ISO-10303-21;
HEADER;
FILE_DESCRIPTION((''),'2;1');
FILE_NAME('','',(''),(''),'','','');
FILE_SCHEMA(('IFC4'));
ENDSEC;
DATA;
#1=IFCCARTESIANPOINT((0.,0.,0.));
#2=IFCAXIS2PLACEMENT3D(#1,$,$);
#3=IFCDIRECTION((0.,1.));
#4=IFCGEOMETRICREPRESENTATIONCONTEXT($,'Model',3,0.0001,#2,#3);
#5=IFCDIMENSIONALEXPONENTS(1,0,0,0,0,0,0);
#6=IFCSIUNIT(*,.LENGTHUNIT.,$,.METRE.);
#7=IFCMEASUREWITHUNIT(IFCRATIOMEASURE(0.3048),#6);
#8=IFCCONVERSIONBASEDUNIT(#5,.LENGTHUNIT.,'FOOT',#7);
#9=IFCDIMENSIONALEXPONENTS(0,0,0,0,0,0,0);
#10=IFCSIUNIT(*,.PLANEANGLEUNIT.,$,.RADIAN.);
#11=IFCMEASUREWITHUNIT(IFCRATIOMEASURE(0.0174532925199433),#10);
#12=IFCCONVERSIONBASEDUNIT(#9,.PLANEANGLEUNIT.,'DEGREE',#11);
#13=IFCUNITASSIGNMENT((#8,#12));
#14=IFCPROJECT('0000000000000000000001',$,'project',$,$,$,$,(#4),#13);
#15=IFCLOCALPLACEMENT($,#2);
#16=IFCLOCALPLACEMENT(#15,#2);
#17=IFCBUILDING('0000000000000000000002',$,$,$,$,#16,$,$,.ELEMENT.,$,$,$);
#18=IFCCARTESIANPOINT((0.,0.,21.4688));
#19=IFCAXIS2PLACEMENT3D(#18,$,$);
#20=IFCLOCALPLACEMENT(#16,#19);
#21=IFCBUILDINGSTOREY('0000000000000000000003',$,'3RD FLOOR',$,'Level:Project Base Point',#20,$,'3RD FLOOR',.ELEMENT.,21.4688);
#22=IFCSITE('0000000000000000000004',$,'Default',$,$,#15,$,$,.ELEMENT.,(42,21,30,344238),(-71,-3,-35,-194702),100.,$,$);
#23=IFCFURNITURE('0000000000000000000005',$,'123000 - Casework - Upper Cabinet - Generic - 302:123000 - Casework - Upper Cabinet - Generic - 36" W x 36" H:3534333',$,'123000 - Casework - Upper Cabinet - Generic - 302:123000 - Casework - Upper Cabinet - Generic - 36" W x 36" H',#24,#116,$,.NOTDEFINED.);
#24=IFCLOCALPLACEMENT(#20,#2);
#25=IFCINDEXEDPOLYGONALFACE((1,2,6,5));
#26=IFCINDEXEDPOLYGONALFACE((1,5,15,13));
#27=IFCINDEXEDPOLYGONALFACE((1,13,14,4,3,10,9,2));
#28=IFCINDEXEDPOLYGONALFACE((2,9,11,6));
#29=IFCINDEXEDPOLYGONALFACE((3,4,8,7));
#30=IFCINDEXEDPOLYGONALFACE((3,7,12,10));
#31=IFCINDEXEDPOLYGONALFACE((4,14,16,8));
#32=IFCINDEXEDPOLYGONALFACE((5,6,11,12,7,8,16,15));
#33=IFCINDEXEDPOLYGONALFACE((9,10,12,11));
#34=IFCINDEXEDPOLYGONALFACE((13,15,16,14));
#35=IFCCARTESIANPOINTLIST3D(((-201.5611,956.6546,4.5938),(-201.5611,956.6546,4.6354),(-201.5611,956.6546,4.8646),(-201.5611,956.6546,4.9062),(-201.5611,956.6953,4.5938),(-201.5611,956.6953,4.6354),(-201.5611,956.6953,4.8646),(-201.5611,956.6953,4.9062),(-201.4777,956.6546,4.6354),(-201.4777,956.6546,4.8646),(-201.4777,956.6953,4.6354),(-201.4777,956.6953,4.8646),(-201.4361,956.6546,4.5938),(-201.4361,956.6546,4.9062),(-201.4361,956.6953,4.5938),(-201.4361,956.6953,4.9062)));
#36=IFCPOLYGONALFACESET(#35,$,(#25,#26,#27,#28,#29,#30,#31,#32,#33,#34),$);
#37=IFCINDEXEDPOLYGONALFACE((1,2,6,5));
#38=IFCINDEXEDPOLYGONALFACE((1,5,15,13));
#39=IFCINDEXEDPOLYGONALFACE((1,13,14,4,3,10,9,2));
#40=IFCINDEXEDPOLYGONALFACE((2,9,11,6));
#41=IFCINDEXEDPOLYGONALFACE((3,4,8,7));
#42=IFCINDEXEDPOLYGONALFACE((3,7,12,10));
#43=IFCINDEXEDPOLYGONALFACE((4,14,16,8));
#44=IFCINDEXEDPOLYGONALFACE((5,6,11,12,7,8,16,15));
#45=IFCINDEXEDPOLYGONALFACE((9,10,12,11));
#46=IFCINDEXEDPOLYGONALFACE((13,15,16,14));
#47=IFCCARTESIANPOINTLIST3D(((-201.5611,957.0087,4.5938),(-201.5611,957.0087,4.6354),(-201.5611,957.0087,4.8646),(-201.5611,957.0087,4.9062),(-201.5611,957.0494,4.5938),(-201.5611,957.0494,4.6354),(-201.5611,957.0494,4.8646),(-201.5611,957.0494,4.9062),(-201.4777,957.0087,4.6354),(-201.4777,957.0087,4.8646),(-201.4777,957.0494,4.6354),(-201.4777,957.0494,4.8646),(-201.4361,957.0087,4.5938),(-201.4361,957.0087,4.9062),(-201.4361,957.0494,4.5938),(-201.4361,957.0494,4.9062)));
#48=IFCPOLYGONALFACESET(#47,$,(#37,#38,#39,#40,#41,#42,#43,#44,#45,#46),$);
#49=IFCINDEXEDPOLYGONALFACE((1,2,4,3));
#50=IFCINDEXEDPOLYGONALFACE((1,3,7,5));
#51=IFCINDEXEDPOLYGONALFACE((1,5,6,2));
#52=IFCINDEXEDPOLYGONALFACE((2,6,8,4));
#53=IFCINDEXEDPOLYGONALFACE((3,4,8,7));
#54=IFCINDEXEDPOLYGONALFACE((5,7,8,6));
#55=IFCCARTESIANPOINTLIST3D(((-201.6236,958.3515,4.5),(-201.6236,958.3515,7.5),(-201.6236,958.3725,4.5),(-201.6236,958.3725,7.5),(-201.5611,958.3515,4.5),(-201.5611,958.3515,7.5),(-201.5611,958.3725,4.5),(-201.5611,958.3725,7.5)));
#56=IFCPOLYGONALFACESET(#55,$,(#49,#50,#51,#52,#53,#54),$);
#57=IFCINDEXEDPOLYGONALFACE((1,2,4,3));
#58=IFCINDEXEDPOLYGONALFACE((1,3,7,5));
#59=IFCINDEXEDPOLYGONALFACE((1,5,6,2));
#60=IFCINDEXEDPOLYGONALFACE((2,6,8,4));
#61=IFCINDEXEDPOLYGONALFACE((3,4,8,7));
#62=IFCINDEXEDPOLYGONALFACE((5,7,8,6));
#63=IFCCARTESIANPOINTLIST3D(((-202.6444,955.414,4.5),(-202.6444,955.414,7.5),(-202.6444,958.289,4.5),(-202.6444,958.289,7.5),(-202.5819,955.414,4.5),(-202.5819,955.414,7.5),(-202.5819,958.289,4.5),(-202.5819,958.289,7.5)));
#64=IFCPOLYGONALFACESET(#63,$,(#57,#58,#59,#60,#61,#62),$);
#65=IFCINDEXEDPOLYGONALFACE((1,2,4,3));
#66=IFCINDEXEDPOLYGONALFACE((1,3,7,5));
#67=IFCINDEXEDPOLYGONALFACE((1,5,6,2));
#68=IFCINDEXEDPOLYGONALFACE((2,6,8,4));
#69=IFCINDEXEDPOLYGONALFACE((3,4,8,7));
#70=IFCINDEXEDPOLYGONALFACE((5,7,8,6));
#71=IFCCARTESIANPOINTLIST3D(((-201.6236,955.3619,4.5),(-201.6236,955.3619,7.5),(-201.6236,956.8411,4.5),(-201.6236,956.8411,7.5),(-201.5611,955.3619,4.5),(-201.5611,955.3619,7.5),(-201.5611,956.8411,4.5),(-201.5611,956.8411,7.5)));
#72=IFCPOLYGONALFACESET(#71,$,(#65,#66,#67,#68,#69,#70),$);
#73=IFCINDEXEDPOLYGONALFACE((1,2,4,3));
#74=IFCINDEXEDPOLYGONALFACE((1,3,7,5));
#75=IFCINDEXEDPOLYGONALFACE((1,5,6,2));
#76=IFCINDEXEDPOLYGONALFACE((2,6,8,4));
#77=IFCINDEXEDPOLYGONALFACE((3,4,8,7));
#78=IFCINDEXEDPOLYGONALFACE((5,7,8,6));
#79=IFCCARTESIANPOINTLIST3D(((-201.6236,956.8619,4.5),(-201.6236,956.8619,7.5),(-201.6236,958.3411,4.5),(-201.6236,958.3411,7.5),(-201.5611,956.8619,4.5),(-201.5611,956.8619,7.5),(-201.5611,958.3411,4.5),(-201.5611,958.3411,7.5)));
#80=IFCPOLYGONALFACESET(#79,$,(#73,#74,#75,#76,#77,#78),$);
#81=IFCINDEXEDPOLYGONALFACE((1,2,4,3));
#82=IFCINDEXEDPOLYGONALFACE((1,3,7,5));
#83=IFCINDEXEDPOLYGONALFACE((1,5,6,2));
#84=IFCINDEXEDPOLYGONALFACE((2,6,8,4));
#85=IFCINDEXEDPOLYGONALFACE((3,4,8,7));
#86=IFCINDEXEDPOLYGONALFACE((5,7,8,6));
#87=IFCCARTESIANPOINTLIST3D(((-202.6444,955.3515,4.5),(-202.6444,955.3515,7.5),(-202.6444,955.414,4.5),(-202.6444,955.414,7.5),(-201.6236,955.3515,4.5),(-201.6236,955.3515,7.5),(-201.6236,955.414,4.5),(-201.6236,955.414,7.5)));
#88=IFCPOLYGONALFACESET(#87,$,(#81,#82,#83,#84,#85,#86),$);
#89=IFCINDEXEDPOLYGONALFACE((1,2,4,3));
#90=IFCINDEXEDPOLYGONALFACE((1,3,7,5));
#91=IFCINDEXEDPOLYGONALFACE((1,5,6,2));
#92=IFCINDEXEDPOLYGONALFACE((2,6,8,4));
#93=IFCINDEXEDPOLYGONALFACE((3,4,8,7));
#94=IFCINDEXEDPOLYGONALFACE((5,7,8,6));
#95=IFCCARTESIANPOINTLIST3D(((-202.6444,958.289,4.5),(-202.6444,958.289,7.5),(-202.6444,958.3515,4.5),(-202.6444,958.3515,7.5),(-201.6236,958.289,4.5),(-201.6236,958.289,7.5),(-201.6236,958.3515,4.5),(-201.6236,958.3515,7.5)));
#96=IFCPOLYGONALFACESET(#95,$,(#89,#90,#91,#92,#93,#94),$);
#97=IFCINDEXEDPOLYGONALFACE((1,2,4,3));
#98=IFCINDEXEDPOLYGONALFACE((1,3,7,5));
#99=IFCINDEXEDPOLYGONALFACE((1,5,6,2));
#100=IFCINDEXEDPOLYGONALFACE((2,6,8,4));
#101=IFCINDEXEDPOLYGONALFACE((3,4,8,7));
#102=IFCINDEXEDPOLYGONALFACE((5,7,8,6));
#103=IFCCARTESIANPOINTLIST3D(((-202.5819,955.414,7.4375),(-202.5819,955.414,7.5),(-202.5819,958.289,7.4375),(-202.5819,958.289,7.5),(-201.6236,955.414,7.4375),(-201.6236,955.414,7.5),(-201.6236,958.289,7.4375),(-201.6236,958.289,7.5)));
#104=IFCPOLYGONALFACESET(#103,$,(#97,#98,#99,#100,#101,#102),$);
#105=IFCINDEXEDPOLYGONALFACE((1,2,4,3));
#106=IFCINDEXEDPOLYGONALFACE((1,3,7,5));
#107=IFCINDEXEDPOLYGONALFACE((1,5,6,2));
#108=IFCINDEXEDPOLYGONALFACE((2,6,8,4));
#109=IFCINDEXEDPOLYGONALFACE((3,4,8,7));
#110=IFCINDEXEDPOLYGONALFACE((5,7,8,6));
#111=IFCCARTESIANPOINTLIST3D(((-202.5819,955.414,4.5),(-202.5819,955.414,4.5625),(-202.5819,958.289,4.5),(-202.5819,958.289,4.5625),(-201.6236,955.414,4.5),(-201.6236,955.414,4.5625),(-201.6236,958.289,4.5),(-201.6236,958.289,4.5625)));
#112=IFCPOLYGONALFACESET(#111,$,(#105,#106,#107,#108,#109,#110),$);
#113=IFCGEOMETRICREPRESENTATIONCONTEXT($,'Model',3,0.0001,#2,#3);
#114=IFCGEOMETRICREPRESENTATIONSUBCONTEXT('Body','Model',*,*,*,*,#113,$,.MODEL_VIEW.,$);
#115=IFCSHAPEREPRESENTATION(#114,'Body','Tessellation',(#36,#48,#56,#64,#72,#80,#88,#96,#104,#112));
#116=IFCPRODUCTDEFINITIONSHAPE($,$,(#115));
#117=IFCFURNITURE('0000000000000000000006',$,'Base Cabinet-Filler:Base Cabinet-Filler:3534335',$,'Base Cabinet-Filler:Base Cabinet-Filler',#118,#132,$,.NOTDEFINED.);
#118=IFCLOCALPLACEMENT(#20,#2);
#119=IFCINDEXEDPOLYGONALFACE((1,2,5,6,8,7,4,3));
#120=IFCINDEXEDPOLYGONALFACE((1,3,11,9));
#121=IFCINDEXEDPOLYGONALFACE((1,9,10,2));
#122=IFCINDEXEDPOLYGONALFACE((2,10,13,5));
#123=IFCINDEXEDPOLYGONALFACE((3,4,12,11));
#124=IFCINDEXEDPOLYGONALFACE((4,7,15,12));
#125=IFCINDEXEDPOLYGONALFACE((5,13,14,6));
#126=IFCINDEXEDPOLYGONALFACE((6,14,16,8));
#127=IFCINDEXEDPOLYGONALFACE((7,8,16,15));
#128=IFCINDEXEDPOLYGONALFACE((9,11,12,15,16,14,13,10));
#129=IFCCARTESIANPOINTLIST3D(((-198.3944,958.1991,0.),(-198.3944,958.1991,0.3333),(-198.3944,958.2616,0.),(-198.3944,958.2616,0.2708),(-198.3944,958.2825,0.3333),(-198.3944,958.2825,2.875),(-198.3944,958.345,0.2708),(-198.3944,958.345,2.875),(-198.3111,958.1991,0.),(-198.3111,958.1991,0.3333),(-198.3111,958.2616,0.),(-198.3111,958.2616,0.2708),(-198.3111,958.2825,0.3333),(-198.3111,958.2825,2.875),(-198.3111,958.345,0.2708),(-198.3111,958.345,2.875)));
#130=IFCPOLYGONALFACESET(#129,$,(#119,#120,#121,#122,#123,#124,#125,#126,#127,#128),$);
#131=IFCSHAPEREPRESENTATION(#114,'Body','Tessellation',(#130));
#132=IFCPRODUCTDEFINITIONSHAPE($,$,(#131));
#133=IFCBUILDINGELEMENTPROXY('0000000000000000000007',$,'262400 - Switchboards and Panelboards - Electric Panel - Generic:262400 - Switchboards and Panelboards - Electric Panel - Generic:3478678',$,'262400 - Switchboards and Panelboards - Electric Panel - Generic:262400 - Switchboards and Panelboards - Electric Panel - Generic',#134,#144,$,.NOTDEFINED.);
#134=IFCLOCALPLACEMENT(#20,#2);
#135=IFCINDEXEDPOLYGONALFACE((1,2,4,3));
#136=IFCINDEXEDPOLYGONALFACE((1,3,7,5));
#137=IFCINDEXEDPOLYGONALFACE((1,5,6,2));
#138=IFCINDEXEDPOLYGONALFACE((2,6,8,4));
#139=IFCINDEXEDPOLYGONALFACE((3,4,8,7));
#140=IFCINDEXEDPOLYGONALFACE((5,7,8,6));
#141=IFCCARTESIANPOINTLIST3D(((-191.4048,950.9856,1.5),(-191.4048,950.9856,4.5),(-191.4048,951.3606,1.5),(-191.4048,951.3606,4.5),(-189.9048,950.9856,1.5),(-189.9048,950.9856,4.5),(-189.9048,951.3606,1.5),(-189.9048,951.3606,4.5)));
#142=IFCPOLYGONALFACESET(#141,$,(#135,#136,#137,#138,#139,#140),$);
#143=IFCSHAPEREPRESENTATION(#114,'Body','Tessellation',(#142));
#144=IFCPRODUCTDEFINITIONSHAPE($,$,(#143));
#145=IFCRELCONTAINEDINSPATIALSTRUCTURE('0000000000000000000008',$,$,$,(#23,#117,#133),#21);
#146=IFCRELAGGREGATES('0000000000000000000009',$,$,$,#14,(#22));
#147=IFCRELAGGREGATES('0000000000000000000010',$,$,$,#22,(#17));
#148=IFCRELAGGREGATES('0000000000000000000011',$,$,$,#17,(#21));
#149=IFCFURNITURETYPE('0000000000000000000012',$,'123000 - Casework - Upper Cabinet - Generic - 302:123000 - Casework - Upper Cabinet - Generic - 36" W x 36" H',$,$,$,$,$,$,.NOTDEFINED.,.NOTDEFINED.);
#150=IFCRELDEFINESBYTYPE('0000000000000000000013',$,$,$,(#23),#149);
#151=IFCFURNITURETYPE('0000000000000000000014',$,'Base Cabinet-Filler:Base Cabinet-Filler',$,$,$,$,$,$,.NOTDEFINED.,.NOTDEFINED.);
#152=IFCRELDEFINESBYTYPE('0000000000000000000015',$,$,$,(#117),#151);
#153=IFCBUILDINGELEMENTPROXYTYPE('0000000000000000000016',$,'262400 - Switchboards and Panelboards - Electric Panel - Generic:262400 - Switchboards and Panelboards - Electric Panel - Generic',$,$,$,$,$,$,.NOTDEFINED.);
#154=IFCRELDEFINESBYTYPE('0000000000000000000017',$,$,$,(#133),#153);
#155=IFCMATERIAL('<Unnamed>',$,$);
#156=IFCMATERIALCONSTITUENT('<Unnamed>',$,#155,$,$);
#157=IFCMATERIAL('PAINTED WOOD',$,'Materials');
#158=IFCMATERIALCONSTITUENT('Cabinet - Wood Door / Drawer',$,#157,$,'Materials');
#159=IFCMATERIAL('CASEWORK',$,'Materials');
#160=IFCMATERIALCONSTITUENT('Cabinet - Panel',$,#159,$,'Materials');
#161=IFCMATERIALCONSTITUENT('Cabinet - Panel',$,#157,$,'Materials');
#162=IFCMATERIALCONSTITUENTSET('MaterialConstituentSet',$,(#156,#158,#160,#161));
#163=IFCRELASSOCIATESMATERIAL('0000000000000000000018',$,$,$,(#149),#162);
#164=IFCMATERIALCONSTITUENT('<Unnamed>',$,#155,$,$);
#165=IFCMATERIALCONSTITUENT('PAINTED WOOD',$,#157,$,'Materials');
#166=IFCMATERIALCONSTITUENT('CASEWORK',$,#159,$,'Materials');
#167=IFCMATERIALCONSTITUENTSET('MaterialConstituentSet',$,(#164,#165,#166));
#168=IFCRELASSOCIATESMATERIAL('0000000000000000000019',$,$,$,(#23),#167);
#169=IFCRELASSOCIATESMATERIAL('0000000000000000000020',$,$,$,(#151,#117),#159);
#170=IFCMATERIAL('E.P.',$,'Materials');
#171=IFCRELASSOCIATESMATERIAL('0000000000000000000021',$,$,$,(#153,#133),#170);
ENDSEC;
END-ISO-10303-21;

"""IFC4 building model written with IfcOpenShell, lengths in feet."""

from ifc_helpers import new_model, entity, si_unit, converted_unit, direction, frame, frame_2d, origin, origin_2d_with_axis, place, context, subcontext, project, spatial, polyline, rectangle, outline, extrude, source, transform, mapped, material, constituent, constituent_set, type_object, type_shapes, element, save


model = new_model("IFC4")

# Units and contexts
model_context_1 = context("Model", 3, precision=0.0001, world=origin(), true_north=direction((0.0, 1.0)))
model_context_2 = context("Model", 3, precision=0.0001, world=origin(), true_north=direction((0.0, 1.0)))
body_context = subcontext(model_context_2, "Body", "Model", "MODEL_VIEW")
ifc_project = project(units=[converted_unit("LENGTHUNIT", "FOOT", entity("IfcRatioMeasure", 0.3048), si_unit("LENGTHUNIT", "METRE"), dimensions=[1, 0, 0, 0, 0, 0, 0]), converted_unit("PLANEANGLEUNIT", "DEGREE", entity("IfcRatioMeasure", 0.0174532925199433), si_unit("PLANEANGLEUNIT", "RADIAN"), dimensions=[0, 0, 0, 0, 0, 0, 0])], contexts=[model_context_1])

# Site, building, storey
site_placement = place(None, origin())
site = spatial("IfcSite", under=ifc_project, at=site_placement, Name="Default", CompositionType="ELEMENT", RefLatitude=(42, 21, 30, 344238), RefLongitude=(-71, -3, -35, -194702), RefElevation=100.0)
building_placement = place(site_placement, origin())
building = spatial("IfcBuilding", under=site, at=building_placement, CompositionType="ELEMENT")
storey_placement = place(building_placement, frame((0.0, 0.0, 21.4688)))
storey = spatial("IfcBuildingStorey", under=building, at=storey_placement, Name="3RD FLOOR", ObjectType="Level:Project Base Point", LongName="3RD FLOOR", CompositionType="ELEMENT", Elevation=21.4688)

# Furniture
ifc_material_1 = material(Name="CASEWORK", Category="Materials")
ifc_material_2 = material(Name="PAINTED WOOD", Category="Materials")
ifc_material_3 = material(Name="<Unnamed>")
ifc_constituent_1 = constituent(ifc_material_3, Name="<Unnamed>")
ifc_constituent_2 = constituent(ifc_material_2, Name="PAINTED WOOD", Category="Materials")
ifc_constituent_3 = constituent(ifc_material_1, Name="CASEWORK", Category="Materials")
ifc_constituent_set_1 = constituent_set(constituents=[ifc_constituent_1, ifc_constituent_2, ifc_constituent_3], Name="MaterialConstituentSet")
ifc_constituent_4 = constituent(ifc_material_3, Name="<Unnamed>")
ifc_constituent_5 = constituent(ifc_material_2, Name="Cabinet - Wood Door / Drawer", Category="Materials")
ifc_constituent_6 = constituent(ifc_material_1, Name="Cabinet - Panel", Category="Materials")
ifc_constituent_7 = constituent(ifc_material_2, Name="Cabinet - Panel", Category="Materials")
ifc_constituent_set_2 = constituent_set(constituents=[ifc_constituent_4, ifc_constituent_5, ifc_constituent_6, ifc_constituent_7], Name="MaterialConstituentSet")
furniture_type_1 = type_object("IfcFurnitureType", Name="123000 - Casework - Upper Cabinet - Generic - 302:123000 - Casework - Upper Cabinet - Generic - 36\" W x 36\" H", AssemblyPlace="NOTDEFINED", PredefinedType="NOTDEFINED", material=ifc_constituent_set_2)
shared_shape_1 = source(origin(), body_context, "Body", "SweptSolid", [
    extrude(outline(polyline([(0.1146, -0.0521), (0.1562, -0.0521), (0.1562, 0.0729), (-0.1562, 0.0729), (-0.1562, -0.0521), (-0.1146, -0.0521), (-0.1146, 0.0313), (0.1146, 0.0313), (0.1146, -0.0521)])), frame((1.303, 0.0729, 0.25), z_axis=(1.0, 0.0, 0.0), x_axis=(0.0, 0.0, 1.0)), (0.0, 0.0, 1.0), 0.0407),
    extrude(outline(polyline([(0.1146, -0.0521), (0.1562, -0.0521), (0.1562, 0.0729), (-0.1562, 0.0729), (-0.1562, -0.0521), (-0.1146, -0.0521), (-0.1146, 0.0313), (0.1146, 0.0313), (0.1146, -0.0521)])), frame((1.6572, 0.0729, 0.25), z_axis=(1.0, 0.0, 0.0), x_axis=(0.0, 0.0, 1.0)), (0.0, 0.0, 1.0), 0.0407),
    extrude(rectangle(XDim=0.0625, YDim=0.021, at=frame_2d((0.0, 0.0), x_axis=(1.0, 0.0))), frame((3.0105, 0.1562, 0.0), z_axis=(0.0, 0.0, 1.0), x_axis=(0.0, -1.0, 0.0)), (0.0, 0.0, 1.0), 3.0),
    extrude(rectangle(XDim=0.0625, YDim=2.875, at=origin_2d_with_axis()), frame((1.5, 1.177, 0.0), z_axis=(0.0, 0.0, 1.0), x_axis=(0.0, 1.0, 0.0)), (0.0, 0.0, 1.0), 3.0),
    extrude(rectangle(XDim=0.0625, YDim=1.4792, at=frame_2d((0.0, 0.0), x_axis=(1.0, 0.0))), frame((0.75, 0.1562, 0.0), z_axis=(0.0, 0.0, 1.0), x_axis=(0.0, -1.0, 0.0)), (0.0, 0.0, 1.0), 3.0),
    extrude(rectangle(XDim=0.0625, YDim=1.4792, at=origin_2d_with_axis()), frame((2.25, 0.1562, 0.0), z_axis=(0.0, 0.0, 1.0), x_axis=(0.0, -1.0, 0.0)), (0.0, 0.0, 1.0), 3.0),
    extrude(rectangle(XDim=0.0625, YDim=1.0208, at=origin_2d_with_axis()), frame((0.0312, 0.6979, 0.0), z_axis=(0.0, 0.0, 1.0), x_axis=(-1.0, 0.0, 0.0)), (0.0, 0.0, 1.0), 3.0),
    extrude(rectangle(XDim=0.0625, YDim=1.0208, at=origin_2d_with_axis()), frame((2.9688, 0.6979, 0.0), z_axis=(0.0, 0.0, 1.0), x_axis=(-1.0, 0.0, 0.0)), (0.0, 0.0, 1.0), 3.0),
    extrude(rectangle(XDim=2.875, YDim=0.9583, at=frame_2d((0.0, 0.0), x_axis=(1.0, 0.0))), frame((1.5, 0.6666, 2.9375), z_axis=(0.0, 0.0, 1.0), x_axis=(-1.0, 0.0, 0.0)), (0.0, 0.0, 1.0), 0.0625),
    extrude(rectangle(XDim=2.875, YDim=0.9583, at=frame_2d((0.0, 0.0), x_axis=(1.0, 0.0))), frame((1.5, 0.6666, 0.0), z_axis=(0.0, 0.0, 1.0), x_axis=(-1.0, 0.0, 0.0)), (0.0, 0.0, 1.0), 0.0625),
])
type_shapes(furniture_type_1, [shared_shape_1])
furniture_1_placement = place(storey_placement, frame((-201.4361, 955.3515, 4.5), z_axis=(0.0, 0.0, 1.0), x_axis=(0.0, 1.0, 0.0)))
element("IfcFurniture", 1, at=furniture_1_placement, inside=storey, type_object=furniture_type_1, material=ifc_constituent_set_1, Name="123000 - Casework - Upper Cabinet - Generic - 302:123000 - Casework - Upper Cabinet - Generic - 36\" W x 36\" H:3534333", ObjectType="123000 - Casework - Upper Cabinet - Generic - 302:123000 - Casework - Upper Cabinet - Generic - 36\" W x 36\" H", PredefinedType="NOTDEFINED", context=body_context, shape_type="MappedRepresentation", body=[
    mapped(shared_shape_1, transform((0.0, 0.0, 0.0), scale=1.0)),
])
furniture_type_2 = type_object("IfcFurnitureType", Name="Base Cabinet-Filler:Base Cabinet-Filler", AssemblyPlace="NOTDEFINED", PredefinedType="NOTDEFINED", material=ifc_material_1)
shared_shape_2 = source(origin(), body_context, "Body", "SweptSolid", [
    extrude(outline(polyline([(-0.0729, 0.599), (-0.0729, -2.0052), (-0.0104, -2.0052), (-0.0104, 0.5365), (0.0729, 0.5365), (0.0729, 0.8698), (0.0104, 0.8698), (0.0104, 0.599), (-0.0729, 0.599)])), frame((0.0, 0.0729, 0.8698), z_axis=(-1.0, 0.0, 0.0), x_axis=(0.0, 1.0, 0.0)), (0.0, 0.0, -1.0), 0.0833),
])
type_shapes(furniture_type_2, [shared_shape_2])
furniture_2_placement = place(storey_placement, frame((-198.3111, 958.345, 0.0), z_axis=(0.0, 0.0, 1.0), x_axis=(-1.0, 0.0, 0.0)))
element("IfcFurniture", 2, at=furniture_2_placement, inside=storey, type_object=furniture_type_2, material=ifc_material_1, Name="Base Cabinet-Filler:Base Cabinet-Filler:3534335", ObjectType="Base Cabinet-Filler:Base Cabinet-Filler", PredefinedType="NOTDEFINED", context=body_context, shape_type="MappedRepresentation", body=[
    mapped(shared_shape_2, transform((0.0, 0.0, 0.0), scale=1.0)),
])

# Building element proxy
ifc_material_4 = material(Name="E.P.", Category="Materials")
building_element_proxy_type_1 = type_object("IfcBuildingElementProxyType", Name="262400 - Switchboards and Panelboards - Electric Panel - Generic:262400 - Switchboards and Panelboards - Electric Panel - Generic", PredefinedType="NOTDEFINED", material=ifc_material_4)
shared_shape_3 = source(origin(), body_context, "Body", "SweptSolid", [
    extrude(rectangle(XDim=0.375, YDim=1.5, at=origin_2d_with_axis()), frame((0.75, 0.1875, 0.0), z_axis=(0.0, 0.0, 1.0), x_axis=(0.0, 1.0, 0.0)), (0.0, 0.0, 1.0), 3.0),
])
type_shapes(building_element_proxy_type_1, [shared_shape_3])
proxy_1_placement = place(storey_placement, frame((-191.4048, 950.9856, 1.5)))
element("IfcBuildingElementProxy", 3, at=proxy_1_placement, inside=storey, type_object=building_element_proxy_type_1, material=ifc_material_4, Name="262400 - Switchboards and Panelboards - Electric Panel - Generic:262400 - Switchboards and Panelboards - Electric Panel - Generic:3478678", ObjectType="262400 - Switchboards and Panelboards - Electric Panel - Generic:262400 - Switchboards and Panelboards - Electric Panel - Generic", PredefinedType="NOTDEFINED", context=body_context, shape_type="MappedRepresentation", body=[
    mapped(shared_shape_3, transform((0.0, 0.0, 0.0), scale=1.0)),
])

save(model, "model.ifc")
